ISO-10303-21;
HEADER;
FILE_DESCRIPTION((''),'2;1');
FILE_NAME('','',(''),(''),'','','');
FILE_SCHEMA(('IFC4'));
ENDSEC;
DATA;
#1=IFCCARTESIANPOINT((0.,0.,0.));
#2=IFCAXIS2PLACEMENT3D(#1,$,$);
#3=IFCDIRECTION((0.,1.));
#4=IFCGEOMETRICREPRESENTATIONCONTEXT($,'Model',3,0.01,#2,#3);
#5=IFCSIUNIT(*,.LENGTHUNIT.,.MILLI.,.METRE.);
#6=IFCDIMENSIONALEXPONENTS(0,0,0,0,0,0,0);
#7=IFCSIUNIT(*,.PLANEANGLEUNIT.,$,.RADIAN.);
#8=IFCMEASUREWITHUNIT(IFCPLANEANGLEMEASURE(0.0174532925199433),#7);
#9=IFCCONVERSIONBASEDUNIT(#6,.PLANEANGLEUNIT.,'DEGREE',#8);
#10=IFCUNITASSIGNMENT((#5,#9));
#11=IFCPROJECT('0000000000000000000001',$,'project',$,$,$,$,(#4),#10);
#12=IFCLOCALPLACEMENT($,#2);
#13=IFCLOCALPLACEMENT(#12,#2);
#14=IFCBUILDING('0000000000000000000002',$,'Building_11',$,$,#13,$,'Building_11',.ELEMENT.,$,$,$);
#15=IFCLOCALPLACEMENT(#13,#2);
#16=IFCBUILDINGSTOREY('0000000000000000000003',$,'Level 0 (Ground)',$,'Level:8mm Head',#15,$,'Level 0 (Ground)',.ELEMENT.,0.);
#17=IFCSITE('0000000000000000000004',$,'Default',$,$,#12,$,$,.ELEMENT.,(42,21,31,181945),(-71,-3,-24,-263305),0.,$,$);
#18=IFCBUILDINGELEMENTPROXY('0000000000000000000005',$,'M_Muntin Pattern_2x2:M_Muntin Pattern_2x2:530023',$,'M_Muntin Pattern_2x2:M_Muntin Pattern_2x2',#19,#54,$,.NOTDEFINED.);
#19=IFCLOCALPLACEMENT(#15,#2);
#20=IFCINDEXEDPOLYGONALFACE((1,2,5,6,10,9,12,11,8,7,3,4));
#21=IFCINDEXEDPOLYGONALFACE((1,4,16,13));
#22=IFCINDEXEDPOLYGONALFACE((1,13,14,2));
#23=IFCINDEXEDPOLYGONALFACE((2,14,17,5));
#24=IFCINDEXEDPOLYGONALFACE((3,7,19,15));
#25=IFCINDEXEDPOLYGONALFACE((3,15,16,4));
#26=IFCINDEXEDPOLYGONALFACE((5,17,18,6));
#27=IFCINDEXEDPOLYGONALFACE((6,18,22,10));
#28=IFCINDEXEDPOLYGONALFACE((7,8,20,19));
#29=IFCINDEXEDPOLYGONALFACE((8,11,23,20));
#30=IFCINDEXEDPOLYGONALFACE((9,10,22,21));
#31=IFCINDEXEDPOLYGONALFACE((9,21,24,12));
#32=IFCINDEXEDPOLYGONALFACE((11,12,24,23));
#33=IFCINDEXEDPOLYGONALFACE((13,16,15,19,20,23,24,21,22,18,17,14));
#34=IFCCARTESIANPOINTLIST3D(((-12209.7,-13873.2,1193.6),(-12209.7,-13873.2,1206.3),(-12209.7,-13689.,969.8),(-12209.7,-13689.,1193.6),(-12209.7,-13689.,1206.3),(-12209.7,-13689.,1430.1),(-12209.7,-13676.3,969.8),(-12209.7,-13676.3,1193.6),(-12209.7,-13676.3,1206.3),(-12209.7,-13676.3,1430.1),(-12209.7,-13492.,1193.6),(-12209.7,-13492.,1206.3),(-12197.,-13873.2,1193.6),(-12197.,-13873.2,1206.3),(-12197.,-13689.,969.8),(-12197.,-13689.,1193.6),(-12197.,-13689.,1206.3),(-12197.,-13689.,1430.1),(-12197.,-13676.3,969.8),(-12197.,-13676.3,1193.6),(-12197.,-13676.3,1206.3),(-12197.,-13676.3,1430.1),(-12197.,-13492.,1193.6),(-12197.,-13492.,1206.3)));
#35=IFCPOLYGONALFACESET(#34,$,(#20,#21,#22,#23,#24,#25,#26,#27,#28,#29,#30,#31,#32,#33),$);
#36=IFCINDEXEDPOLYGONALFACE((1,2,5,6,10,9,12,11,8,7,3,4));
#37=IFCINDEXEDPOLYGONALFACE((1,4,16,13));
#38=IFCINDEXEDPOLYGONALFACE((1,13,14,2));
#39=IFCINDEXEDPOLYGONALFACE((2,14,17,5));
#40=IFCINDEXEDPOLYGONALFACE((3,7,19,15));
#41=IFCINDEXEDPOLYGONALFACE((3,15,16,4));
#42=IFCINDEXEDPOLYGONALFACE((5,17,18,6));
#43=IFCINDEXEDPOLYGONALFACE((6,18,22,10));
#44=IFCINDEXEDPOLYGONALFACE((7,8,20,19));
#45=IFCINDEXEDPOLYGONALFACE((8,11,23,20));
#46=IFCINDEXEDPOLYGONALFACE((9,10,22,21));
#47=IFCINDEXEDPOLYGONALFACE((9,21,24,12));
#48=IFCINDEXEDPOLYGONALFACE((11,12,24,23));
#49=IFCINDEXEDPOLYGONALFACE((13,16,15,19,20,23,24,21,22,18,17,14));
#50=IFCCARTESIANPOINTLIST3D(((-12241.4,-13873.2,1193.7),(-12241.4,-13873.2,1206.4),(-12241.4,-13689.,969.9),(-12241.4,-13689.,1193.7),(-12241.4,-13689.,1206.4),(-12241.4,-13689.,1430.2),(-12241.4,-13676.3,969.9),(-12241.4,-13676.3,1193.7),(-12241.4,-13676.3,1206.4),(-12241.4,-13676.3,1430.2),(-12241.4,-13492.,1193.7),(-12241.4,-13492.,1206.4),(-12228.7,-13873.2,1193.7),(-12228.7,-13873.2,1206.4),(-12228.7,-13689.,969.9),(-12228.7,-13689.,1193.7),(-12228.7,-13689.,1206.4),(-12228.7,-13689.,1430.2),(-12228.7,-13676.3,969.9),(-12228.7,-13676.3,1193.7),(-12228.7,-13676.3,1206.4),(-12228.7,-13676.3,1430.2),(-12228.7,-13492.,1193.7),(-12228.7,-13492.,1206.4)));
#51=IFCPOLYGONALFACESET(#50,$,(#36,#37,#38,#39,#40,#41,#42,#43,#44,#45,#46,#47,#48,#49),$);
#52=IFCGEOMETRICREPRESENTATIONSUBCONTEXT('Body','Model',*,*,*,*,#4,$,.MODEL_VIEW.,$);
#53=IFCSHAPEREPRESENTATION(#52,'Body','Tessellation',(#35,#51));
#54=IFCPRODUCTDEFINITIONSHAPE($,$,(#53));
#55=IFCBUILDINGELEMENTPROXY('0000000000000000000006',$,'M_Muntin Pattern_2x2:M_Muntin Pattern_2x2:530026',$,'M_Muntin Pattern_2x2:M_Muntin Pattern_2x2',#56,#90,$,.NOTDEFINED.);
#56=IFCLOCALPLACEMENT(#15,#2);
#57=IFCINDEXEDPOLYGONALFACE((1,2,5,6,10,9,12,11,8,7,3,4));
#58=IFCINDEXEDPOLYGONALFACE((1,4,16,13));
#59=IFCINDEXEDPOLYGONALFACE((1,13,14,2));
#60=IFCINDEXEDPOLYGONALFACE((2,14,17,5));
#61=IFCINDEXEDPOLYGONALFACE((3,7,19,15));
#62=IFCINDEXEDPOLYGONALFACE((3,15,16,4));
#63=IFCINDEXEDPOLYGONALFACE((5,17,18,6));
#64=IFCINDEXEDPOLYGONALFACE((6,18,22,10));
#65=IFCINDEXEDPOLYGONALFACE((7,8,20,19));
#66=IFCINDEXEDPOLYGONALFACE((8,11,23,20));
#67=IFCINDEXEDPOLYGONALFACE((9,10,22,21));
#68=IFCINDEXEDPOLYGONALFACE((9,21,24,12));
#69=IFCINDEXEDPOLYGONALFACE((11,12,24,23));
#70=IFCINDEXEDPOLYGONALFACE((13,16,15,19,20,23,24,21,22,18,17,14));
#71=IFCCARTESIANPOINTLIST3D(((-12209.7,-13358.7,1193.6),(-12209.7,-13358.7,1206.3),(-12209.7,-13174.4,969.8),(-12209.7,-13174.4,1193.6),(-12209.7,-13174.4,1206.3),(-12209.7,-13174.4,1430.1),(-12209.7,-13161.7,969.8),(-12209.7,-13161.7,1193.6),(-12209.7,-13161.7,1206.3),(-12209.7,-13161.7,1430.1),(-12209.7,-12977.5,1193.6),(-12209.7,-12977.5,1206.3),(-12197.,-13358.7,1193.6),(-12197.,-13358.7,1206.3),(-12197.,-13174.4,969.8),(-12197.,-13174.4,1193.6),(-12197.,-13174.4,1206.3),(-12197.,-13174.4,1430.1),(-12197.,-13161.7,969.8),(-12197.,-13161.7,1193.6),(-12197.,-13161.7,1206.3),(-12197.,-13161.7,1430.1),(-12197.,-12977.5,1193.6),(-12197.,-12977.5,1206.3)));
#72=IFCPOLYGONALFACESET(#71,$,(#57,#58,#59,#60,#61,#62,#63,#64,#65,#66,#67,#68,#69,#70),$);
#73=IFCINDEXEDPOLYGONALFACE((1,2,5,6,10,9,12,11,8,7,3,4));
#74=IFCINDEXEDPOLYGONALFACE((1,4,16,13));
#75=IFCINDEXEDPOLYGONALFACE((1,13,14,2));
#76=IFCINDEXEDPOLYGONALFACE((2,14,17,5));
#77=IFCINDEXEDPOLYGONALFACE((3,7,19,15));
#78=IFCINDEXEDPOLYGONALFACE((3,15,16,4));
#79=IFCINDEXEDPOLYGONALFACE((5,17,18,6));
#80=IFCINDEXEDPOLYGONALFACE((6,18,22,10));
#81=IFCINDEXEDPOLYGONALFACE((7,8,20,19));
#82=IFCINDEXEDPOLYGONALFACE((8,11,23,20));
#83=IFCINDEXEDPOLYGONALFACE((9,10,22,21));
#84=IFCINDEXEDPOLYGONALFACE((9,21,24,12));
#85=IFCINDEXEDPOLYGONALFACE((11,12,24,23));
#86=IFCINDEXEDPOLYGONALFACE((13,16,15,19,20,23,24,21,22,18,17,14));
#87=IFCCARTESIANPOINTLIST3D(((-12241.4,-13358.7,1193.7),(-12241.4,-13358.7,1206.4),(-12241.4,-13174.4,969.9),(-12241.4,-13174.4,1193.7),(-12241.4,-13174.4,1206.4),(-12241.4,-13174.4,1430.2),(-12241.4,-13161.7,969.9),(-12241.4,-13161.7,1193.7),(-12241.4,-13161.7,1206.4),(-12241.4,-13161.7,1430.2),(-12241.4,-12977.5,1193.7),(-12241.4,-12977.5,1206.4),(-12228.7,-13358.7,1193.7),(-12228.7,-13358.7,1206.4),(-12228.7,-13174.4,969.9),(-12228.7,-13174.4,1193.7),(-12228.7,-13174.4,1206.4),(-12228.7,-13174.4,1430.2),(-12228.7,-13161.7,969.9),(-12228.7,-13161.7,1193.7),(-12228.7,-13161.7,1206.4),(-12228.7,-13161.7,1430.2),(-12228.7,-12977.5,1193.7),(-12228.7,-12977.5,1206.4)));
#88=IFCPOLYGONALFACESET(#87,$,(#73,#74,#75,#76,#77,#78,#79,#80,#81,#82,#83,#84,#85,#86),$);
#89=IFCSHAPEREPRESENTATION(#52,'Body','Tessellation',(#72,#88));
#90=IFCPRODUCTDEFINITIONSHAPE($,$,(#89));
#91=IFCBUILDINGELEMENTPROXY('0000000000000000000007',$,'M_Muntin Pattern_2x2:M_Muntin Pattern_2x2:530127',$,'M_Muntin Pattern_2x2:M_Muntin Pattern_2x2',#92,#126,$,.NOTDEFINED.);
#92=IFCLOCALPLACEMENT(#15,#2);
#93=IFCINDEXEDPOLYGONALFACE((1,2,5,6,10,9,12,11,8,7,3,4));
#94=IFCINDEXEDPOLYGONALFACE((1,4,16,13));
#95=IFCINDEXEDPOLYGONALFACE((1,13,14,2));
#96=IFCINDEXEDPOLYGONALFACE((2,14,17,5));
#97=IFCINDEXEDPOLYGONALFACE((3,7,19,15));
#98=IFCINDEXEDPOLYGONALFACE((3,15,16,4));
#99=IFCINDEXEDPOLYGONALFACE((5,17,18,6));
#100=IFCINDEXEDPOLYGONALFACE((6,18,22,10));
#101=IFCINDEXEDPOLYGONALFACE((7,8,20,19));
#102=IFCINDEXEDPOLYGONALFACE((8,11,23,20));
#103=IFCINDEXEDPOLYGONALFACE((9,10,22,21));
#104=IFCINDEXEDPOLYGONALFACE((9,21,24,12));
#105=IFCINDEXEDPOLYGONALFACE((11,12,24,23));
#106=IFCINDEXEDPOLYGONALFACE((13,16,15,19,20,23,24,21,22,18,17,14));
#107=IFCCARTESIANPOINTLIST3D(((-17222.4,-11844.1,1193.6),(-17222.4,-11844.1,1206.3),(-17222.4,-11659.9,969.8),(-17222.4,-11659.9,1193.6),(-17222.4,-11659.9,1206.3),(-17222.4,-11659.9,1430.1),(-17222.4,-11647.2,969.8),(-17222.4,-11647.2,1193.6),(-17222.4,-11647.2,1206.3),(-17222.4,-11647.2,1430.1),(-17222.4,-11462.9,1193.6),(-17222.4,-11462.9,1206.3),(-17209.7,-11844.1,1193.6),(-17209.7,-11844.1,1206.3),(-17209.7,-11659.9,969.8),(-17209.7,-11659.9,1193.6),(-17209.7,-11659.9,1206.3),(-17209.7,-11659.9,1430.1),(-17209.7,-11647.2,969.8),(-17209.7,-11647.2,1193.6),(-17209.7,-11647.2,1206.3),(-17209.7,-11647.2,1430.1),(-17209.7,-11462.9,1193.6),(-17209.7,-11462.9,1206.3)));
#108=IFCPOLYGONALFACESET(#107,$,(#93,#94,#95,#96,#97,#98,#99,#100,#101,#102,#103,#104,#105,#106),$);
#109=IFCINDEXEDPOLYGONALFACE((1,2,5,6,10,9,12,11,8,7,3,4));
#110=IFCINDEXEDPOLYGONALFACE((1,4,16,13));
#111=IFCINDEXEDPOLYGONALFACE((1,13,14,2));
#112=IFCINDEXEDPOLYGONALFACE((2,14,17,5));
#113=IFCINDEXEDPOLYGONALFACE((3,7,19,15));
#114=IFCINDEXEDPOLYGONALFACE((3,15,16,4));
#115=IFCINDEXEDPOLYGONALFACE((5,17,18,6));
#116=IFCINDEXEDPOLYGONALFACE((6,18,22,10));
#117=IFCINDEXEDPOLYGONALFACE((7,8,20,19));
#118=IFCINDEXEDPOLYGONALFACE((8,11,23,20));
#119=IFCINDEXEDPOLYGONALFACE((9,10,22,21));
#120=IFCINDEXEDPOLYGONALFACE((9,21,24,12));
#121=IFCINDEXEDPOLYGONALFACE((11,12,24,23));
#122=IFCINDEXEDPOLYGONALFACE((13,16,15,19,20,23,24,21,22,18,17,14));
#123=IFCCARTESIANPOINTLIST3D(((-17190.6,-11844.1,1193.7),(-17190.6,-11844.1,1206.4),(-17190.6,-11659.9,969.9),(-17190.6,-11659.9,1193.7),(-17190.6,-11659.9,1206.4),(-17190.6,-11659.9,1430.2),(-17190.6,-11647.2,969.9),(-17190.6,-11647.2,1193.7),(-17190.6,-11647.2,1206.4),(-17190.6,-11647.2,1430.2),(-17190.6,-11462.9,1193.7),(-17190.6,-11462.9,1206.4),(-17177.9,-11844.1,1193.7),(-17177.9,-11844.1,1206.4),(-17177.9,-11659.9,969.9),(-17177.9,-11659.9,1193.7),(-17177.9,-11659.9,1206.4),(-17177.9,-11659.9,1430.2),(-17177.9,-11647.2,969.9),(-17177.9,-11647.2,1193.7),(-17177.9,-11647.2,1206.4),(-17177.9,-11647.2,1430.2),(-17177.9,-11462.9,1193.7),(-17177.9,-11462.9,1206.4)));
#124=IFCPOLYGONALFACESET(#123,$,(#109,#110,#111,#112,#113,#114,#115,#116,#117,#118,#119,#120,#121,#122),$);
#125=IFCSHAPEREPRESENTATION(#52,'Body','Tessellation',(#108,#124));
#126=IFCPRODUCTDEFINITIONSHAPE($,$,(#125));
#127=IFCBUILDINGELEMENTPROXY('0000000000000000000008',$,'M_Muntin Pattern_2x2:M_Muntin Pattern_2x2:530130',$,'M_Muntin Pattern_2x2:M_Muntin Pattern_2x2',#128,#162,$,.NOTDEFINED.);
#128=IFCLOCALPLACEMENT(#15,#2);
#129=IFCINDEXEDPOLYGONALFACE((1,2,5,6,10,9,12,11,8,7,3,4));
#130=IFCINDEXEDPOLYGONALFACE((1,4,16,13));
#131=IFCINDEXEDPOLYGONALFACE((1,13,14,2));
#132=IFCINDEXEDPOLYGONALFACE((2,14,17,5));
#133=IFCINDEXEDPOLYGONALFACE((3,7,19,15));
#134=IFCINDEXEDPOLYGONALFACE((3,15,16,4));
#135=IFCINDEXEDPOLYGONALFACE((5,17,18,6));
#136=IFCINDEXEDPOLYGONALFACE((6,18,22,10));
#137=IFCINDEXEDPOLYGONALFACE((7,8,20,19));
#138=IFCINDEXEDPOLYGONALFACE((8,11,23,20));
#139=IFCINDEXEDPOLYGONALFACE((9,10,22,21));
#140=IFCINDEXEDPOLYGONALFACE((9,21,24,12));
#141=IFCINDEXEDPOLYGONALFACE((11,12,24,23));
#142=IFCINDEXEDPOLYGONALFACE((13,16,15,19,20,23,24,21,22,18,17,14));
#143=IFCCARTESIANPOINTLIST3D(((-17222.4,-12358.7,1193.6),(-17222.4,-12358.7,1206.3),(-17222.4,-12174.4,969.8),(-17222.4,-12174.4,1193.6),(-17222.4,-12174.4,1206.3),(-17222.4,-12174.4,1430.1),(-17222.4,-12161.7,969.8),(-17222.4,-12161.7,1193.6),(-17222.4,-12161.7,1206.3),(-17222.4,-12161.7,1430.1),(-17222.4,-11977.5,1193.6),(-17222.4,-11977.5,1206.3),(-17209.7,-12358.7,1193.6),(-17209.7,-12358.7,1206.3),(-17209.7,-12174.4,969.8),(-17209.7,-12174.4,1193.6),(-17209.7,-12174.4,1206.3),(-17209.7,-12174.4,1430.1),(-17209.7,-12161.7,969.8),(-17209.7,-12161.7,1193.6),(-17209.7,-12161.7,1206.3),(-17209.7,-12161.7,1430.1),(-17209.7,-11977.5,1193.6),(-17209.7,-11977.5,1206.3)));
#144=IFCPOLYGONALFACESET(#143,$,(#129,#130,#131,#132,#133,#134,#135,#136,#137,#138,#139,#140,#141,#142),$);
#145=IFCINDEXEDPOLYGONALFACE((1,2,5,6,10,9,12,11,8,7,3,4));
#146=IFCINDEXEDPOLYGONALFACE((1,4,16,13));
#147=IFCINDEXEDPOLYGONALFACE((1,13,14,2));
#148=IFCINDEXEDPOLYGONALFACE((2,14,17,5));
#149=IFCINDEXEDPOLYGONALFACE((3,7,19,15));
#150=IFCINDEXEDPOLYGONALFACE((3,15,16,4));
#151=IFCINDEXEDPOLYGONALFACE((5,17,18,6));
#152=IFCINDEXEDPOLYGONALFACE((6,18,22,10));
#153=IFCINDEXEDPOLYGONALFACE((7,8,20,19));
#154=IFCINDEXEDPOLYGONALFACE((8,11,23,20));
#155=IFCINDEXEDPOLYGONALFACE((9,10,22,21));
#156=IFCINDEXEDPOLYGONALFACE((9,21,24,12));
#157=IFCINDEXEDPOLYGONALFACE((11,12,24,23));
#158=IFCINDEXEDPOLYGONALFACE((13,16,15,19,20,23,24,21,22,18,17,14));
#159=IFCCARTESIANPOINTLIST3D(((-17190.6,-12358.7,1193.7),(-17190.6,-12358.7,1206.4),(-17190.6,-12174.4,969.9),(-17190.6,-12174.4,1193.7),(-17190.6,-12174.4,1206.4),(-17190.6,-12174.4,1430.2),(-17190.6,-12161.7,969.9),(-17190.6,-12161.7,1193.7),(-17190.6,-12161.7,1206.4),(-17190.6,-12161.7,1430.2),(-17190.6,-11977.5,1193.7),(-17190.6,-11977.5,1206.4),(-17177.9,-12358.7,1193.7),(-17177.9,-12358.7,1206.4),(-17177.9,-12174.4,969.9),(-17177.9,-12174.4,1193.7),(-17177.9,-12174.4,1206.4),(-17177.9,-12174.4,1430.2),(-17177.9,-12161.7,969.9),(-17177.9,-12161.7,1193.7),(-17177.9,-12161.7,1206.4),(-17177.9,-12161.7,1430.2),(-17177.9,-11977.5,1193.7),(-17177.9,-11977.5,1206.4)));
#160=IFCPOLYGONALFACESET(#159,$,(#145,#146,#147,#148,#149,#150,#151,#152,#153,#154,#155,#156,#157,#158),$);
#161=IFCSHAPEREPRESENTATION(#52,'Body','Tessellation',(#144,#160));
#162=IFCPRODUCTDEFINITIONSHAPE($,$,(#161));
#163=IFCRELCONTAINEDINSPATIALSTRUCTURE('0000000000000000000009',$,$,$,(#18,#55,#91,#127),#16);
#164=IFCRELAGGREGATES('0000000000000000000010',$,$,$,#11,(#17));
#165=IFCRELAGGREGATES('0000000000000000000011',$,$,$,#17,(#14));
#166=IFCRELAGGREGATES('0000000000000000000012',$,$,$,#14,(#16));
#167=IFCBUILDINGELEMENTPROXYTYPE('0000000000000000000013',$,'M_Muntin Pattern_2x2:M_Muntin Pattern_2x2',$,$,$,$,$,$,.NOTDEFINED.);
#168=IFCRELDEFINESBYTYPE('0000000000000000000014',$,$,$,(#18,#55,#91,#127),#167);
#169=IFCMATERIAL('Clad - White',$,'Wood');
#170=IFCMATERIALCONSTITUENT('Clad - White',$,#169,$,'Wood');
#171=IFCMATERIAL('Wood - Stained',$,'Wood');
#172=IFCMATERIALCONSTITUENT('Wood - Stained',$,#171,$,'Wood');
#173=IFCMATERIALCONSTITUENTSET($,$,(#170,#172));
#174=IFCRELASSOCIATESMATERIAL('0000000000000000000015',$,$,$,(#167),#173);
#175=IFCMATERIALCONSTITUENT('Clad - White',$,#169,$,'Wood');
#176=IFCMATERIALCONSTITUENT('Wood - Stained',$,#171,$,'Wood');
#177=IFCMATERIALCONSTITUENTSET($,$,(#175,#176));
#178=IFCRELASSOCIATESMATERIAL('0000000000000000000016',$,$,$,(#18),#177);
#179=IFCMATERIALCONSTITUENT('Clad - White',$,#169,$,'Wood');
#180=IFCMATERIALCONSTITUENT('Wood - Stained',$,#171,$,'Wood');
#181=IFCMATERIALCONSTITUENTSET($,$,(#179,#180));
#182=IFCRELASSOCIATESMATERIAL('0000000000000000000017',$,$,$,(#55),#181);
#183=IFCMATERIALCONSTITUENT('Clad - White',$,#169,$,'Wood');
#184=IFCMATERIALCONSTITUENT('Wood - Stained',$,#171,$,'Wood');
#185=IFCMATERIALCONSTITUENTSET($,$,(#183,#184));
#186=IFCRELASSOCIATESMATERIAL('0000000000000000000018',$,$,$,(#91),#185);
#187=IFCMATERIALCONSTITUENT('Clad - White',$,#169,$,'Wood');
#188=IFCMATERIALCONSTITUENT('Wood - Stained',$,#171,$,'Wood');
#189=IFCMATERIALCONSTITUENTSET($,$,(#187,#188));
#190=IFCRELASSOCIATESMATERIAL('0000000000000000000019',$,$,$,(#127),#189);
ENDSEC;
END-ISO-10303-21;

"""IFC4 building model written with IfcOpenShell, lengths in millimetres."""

from ifc_helpers import new_model, entity, si_unit, converted_unit, direction, frame, origin, place, context, subcontext, project, spatial, indexed_curve, outline, extrude, source, transform, mapped, material, constituent, constituent_set, type_object, type_shapes, element, save


model = new_model("IFC4")

# Units and contexts
model_context = context("Model", 3, precision=0.01, world=origin(), true_north=direction((0.0, 1.0)))
body_context = subcontext(model_context, "Body", "Model", "MODEL_VIEW")
ifc_project = project(units=[si_unit("LENGTHUNIT", "METRE", prefix="MILLI"), converted_unit("PLANEANGLEUNIT", "DEGREE", entity("IfcPlaneAngleMeasure", 0.0174532925199433), si_unit("PLANEANGLEUNIT", "RADIAN"), dimensions=[0, 0, 0, 0, 0, 0, 0])], contexts=[model_context])

# Site, building, storey
site_placement = place(None, origin())
site = spatial("IfcSite", under=ifc_project, at=site_placement, Name="Default", CompositionType="ELEMENT", RefLatitude=(42, 21, 31, 181945), RefLongitude=(-71, -3, -24, -263305), RefElevation=0.0)
building_placement = place(site_placement, origin())
building = spatial("IfcBuilding", under=site, at=building_placement, Name="Building_11", LongName="Building_11", CompositionType="ELEMENT")
storey_placement = place(building_placement, origin())
storey = spatial("IfcBuildingStorey", under=building, at=storey_placement, Name="Level 0 (Ground)", ObjectType="Level:8mm Head", LongName="Level 0 (Ground)", CompositionType="ELEMENT", Elevation=0.0)

# Building element proxies
ifc_material_1 = material(Name="Clad - White", Category="Wood")
ifc_material_2 = material(Name="Wood - Stained", Category="Wood")
ifc_constituent_1 = constituent(ifc_material_1, Name="Clad - White", Category="Wood")
ifc_constituent_2 = constituent(ifc_material_2, Name="Wood - Stained", Category="Wood")
ifc_constituent_set_1 = constituent_set(constituents=[ifc_constituent_1, ifc_constituent_2])
ifc_constituent_3 = constituent(ifc_material_1, Name="Clad - White", Category="Wood")
ifc_constituent_4 = constituent(ifc_material_2, Name="Wood - Stained", Category="Wood")
ifc_constituent_set_2 = constituent_set(constituents=[ifc_constituent_3, ifc_constituent_4])
building_element_proxy_type_1 = type_object("IfcBuildingElementProxyType", Name="M_Muntin Pattern_2x2:M_Muntin Pattern_2x2", PredefinedType="NOTDEFINED", material=ifc_constituent_set_2)
shared_shape_1 = source(origin(), body_context, "Body", "SweptSolid", [
    extrude(outline(indexed_curve([(6.4, -6.4), (230.1, -6.4), (230.1, 6.3), (6.4, 6.3), (6.4, 190.6), (-6.3, 190.6), (-6.3, 6.3), (-230.2, 6.3), (-230.2, -6.4), (-6.3, -6.4), (-6.3, -190.6), (6.4, -190.6), (6.4, -6.4)], self_intersect=False)), frame((0.0, -22.2, 230.1), z_axis=(0.0, 1.0, 0.0), x_axis=(0.0, 0.0, 1.0)), (0.0, 0.0, 1.0), 12.7),
    extrude(outline(indexed_curve([(6.4, -6.4), (230.2, -6.4), (230.2, 6.3), (6.4, 6.3), (6.4, 190.6), (-6.3, 190.6), (-6.3, 6.3), (-230.2, 6.3), (-230.2, -6.4), (-6.3, -6.4), (-6.3, -190.6), (6.4, -190.6), (6.4, -6.4)], self_intersect=False)), frame((0.0, 9.5, 230.2), z_axis=(0.0, 1.0, 0.0), x_axis=(0.0, 0.0, 1.0)), (0.0, 0.0, 1.0), 12.7),
])
type_shapes(building_element_proxy_type_1, [shared_shape_1])
proxy_1_placement = place(storey_placement, frame((-12219.2, -13682.6, 969.9), z_axis=(0.0, 0.0, 1.0), x_axis=(0.0, 1.0, 0.0)))
element("IfcBuildingElementProxy", 1, at=proxy_1_placement, inside=storey, type_object=building_element_proxy_type_1, material=ifc_constituent_set_1, Name="M_Muntin Pattern_2x2:M_Muntin Pattern_2x2:530023", ObjectType="M_Muntin Pattern_2x2:M_Muntin Pattern_2x2", PredefinedType="NOTDEFINED", context=body_context, shape_type="MappedRepresentation", body=[
    mapped(shared_shape_1, transform((0.0, 0.0, 0.0), scale=1.0)),
])
ifc_constituent_5 = constituent(ifc_material_1, Name="Clad - White", Category="Wood")
ifc_constituent_6 = constituent(ifc_material_2, Name="Wood - Stained", Category="Wood")
ifc_constituent_set_3 = constituent_set(constituents=[ifc_constituent_5, ifc_constituent_6])
proxy_2_placement = place(storey_placement, frame((-12219.2, -13168.1, 969.9), z_axis=(0.0, 0.0, 1.0), x_axis=(0.0, 1.0, 0.0)))
element("IfcBuildingElementProxy", 2, at=proxy_2_placement, inside=storey, type_object=building_element_proxy_type_1, material=ifc_constituent_set_3, Name="M_Muntin Pattern_2x2:M_Muntin Pattern_2x2:530026", ObjectType="M_Muntin Pattern_2x2:M_Muntin Pattern_2x2", PredefinedType="NOTDEFINED", context=body_context, shape_type="MappedRepresentation", body=[
    mapped(shared_shape_1, transform((0.0, 0.0, 0.0), scale=1.0)),
])
ifc_constituent_7 = constituent(ifc_material_1, Name="Clad - White", Category="Wood")
ifc_constituent_8 = constituent(ifc_material_2, Name="Wood - Stained", Category="Wood")
ifc_constituent_set_4 = constituent_set(constituents=[ifc_constituent_7, ifc_constituent_8])
proxy_3_placement = place(storey_placement, frame((-17200.2, -11653.5, 969.9), z_axis=(0.0, 0.0, 1.0), x_axis=(0.0, -1.0, 0.0)))
element("IfcBuildingElementProxy", 3, at=proxy_3_placement, inside=storey, type_object=building_element_proxy_type_1, material=ifc_constituent_set_4, Name="M_Muntin Pattern_2x2:M_Muntin Pattern_2x2:530127", ObjectType="M_Muntin Pattern_2x2:M_Muntin Pattern_2x2", PredefinedType="NOTDEFINED", context=body_context, shape_type="MappedRepresentation", body=[
    mapped(shared_shape_1, transform((0.0, 0.0, 0.0), scale=1.0)),
])
ifc_constituent_9 = constituent(ifc_material_1, Name="Clad - White", Category="Wood")
ifc_constituent_10 = constituent(ifc_material_2, Name="Wood - Stained", Category="Wood")
ifc_constituent_set_5 = constituent_set(constituents=[ifc_constituent_9, ifc_constituent_10])
proxy_4_placement = place(storey_placement, frame((-17200.2, -12168.1, 969.9), z_axis=(0.0, 0.0, 1.0), x_axis=(0.0, -1.0, 0.0)))
element("IfcBuildingElementProxy", 4, at=proxy_4_placement, inside=storey, type_object=building_element_proxy_type_1, material=ifc_constituent_set_5, Name="M_Muntin Pattern_2x2:M_Muntin Pattern_2x2:530130", ObjectType="M_Muntin Pattern_2x2:M_Muntin Pattern_2x2", PredefinedType="NOTDEFINED", context=body_context, shape_type="MappedRepresentation", body=[
    mapped(shared_shape_1, transform((0.0, 0.0, 0.0), scale=1.0)),
])

save(model, "model.ifc")
